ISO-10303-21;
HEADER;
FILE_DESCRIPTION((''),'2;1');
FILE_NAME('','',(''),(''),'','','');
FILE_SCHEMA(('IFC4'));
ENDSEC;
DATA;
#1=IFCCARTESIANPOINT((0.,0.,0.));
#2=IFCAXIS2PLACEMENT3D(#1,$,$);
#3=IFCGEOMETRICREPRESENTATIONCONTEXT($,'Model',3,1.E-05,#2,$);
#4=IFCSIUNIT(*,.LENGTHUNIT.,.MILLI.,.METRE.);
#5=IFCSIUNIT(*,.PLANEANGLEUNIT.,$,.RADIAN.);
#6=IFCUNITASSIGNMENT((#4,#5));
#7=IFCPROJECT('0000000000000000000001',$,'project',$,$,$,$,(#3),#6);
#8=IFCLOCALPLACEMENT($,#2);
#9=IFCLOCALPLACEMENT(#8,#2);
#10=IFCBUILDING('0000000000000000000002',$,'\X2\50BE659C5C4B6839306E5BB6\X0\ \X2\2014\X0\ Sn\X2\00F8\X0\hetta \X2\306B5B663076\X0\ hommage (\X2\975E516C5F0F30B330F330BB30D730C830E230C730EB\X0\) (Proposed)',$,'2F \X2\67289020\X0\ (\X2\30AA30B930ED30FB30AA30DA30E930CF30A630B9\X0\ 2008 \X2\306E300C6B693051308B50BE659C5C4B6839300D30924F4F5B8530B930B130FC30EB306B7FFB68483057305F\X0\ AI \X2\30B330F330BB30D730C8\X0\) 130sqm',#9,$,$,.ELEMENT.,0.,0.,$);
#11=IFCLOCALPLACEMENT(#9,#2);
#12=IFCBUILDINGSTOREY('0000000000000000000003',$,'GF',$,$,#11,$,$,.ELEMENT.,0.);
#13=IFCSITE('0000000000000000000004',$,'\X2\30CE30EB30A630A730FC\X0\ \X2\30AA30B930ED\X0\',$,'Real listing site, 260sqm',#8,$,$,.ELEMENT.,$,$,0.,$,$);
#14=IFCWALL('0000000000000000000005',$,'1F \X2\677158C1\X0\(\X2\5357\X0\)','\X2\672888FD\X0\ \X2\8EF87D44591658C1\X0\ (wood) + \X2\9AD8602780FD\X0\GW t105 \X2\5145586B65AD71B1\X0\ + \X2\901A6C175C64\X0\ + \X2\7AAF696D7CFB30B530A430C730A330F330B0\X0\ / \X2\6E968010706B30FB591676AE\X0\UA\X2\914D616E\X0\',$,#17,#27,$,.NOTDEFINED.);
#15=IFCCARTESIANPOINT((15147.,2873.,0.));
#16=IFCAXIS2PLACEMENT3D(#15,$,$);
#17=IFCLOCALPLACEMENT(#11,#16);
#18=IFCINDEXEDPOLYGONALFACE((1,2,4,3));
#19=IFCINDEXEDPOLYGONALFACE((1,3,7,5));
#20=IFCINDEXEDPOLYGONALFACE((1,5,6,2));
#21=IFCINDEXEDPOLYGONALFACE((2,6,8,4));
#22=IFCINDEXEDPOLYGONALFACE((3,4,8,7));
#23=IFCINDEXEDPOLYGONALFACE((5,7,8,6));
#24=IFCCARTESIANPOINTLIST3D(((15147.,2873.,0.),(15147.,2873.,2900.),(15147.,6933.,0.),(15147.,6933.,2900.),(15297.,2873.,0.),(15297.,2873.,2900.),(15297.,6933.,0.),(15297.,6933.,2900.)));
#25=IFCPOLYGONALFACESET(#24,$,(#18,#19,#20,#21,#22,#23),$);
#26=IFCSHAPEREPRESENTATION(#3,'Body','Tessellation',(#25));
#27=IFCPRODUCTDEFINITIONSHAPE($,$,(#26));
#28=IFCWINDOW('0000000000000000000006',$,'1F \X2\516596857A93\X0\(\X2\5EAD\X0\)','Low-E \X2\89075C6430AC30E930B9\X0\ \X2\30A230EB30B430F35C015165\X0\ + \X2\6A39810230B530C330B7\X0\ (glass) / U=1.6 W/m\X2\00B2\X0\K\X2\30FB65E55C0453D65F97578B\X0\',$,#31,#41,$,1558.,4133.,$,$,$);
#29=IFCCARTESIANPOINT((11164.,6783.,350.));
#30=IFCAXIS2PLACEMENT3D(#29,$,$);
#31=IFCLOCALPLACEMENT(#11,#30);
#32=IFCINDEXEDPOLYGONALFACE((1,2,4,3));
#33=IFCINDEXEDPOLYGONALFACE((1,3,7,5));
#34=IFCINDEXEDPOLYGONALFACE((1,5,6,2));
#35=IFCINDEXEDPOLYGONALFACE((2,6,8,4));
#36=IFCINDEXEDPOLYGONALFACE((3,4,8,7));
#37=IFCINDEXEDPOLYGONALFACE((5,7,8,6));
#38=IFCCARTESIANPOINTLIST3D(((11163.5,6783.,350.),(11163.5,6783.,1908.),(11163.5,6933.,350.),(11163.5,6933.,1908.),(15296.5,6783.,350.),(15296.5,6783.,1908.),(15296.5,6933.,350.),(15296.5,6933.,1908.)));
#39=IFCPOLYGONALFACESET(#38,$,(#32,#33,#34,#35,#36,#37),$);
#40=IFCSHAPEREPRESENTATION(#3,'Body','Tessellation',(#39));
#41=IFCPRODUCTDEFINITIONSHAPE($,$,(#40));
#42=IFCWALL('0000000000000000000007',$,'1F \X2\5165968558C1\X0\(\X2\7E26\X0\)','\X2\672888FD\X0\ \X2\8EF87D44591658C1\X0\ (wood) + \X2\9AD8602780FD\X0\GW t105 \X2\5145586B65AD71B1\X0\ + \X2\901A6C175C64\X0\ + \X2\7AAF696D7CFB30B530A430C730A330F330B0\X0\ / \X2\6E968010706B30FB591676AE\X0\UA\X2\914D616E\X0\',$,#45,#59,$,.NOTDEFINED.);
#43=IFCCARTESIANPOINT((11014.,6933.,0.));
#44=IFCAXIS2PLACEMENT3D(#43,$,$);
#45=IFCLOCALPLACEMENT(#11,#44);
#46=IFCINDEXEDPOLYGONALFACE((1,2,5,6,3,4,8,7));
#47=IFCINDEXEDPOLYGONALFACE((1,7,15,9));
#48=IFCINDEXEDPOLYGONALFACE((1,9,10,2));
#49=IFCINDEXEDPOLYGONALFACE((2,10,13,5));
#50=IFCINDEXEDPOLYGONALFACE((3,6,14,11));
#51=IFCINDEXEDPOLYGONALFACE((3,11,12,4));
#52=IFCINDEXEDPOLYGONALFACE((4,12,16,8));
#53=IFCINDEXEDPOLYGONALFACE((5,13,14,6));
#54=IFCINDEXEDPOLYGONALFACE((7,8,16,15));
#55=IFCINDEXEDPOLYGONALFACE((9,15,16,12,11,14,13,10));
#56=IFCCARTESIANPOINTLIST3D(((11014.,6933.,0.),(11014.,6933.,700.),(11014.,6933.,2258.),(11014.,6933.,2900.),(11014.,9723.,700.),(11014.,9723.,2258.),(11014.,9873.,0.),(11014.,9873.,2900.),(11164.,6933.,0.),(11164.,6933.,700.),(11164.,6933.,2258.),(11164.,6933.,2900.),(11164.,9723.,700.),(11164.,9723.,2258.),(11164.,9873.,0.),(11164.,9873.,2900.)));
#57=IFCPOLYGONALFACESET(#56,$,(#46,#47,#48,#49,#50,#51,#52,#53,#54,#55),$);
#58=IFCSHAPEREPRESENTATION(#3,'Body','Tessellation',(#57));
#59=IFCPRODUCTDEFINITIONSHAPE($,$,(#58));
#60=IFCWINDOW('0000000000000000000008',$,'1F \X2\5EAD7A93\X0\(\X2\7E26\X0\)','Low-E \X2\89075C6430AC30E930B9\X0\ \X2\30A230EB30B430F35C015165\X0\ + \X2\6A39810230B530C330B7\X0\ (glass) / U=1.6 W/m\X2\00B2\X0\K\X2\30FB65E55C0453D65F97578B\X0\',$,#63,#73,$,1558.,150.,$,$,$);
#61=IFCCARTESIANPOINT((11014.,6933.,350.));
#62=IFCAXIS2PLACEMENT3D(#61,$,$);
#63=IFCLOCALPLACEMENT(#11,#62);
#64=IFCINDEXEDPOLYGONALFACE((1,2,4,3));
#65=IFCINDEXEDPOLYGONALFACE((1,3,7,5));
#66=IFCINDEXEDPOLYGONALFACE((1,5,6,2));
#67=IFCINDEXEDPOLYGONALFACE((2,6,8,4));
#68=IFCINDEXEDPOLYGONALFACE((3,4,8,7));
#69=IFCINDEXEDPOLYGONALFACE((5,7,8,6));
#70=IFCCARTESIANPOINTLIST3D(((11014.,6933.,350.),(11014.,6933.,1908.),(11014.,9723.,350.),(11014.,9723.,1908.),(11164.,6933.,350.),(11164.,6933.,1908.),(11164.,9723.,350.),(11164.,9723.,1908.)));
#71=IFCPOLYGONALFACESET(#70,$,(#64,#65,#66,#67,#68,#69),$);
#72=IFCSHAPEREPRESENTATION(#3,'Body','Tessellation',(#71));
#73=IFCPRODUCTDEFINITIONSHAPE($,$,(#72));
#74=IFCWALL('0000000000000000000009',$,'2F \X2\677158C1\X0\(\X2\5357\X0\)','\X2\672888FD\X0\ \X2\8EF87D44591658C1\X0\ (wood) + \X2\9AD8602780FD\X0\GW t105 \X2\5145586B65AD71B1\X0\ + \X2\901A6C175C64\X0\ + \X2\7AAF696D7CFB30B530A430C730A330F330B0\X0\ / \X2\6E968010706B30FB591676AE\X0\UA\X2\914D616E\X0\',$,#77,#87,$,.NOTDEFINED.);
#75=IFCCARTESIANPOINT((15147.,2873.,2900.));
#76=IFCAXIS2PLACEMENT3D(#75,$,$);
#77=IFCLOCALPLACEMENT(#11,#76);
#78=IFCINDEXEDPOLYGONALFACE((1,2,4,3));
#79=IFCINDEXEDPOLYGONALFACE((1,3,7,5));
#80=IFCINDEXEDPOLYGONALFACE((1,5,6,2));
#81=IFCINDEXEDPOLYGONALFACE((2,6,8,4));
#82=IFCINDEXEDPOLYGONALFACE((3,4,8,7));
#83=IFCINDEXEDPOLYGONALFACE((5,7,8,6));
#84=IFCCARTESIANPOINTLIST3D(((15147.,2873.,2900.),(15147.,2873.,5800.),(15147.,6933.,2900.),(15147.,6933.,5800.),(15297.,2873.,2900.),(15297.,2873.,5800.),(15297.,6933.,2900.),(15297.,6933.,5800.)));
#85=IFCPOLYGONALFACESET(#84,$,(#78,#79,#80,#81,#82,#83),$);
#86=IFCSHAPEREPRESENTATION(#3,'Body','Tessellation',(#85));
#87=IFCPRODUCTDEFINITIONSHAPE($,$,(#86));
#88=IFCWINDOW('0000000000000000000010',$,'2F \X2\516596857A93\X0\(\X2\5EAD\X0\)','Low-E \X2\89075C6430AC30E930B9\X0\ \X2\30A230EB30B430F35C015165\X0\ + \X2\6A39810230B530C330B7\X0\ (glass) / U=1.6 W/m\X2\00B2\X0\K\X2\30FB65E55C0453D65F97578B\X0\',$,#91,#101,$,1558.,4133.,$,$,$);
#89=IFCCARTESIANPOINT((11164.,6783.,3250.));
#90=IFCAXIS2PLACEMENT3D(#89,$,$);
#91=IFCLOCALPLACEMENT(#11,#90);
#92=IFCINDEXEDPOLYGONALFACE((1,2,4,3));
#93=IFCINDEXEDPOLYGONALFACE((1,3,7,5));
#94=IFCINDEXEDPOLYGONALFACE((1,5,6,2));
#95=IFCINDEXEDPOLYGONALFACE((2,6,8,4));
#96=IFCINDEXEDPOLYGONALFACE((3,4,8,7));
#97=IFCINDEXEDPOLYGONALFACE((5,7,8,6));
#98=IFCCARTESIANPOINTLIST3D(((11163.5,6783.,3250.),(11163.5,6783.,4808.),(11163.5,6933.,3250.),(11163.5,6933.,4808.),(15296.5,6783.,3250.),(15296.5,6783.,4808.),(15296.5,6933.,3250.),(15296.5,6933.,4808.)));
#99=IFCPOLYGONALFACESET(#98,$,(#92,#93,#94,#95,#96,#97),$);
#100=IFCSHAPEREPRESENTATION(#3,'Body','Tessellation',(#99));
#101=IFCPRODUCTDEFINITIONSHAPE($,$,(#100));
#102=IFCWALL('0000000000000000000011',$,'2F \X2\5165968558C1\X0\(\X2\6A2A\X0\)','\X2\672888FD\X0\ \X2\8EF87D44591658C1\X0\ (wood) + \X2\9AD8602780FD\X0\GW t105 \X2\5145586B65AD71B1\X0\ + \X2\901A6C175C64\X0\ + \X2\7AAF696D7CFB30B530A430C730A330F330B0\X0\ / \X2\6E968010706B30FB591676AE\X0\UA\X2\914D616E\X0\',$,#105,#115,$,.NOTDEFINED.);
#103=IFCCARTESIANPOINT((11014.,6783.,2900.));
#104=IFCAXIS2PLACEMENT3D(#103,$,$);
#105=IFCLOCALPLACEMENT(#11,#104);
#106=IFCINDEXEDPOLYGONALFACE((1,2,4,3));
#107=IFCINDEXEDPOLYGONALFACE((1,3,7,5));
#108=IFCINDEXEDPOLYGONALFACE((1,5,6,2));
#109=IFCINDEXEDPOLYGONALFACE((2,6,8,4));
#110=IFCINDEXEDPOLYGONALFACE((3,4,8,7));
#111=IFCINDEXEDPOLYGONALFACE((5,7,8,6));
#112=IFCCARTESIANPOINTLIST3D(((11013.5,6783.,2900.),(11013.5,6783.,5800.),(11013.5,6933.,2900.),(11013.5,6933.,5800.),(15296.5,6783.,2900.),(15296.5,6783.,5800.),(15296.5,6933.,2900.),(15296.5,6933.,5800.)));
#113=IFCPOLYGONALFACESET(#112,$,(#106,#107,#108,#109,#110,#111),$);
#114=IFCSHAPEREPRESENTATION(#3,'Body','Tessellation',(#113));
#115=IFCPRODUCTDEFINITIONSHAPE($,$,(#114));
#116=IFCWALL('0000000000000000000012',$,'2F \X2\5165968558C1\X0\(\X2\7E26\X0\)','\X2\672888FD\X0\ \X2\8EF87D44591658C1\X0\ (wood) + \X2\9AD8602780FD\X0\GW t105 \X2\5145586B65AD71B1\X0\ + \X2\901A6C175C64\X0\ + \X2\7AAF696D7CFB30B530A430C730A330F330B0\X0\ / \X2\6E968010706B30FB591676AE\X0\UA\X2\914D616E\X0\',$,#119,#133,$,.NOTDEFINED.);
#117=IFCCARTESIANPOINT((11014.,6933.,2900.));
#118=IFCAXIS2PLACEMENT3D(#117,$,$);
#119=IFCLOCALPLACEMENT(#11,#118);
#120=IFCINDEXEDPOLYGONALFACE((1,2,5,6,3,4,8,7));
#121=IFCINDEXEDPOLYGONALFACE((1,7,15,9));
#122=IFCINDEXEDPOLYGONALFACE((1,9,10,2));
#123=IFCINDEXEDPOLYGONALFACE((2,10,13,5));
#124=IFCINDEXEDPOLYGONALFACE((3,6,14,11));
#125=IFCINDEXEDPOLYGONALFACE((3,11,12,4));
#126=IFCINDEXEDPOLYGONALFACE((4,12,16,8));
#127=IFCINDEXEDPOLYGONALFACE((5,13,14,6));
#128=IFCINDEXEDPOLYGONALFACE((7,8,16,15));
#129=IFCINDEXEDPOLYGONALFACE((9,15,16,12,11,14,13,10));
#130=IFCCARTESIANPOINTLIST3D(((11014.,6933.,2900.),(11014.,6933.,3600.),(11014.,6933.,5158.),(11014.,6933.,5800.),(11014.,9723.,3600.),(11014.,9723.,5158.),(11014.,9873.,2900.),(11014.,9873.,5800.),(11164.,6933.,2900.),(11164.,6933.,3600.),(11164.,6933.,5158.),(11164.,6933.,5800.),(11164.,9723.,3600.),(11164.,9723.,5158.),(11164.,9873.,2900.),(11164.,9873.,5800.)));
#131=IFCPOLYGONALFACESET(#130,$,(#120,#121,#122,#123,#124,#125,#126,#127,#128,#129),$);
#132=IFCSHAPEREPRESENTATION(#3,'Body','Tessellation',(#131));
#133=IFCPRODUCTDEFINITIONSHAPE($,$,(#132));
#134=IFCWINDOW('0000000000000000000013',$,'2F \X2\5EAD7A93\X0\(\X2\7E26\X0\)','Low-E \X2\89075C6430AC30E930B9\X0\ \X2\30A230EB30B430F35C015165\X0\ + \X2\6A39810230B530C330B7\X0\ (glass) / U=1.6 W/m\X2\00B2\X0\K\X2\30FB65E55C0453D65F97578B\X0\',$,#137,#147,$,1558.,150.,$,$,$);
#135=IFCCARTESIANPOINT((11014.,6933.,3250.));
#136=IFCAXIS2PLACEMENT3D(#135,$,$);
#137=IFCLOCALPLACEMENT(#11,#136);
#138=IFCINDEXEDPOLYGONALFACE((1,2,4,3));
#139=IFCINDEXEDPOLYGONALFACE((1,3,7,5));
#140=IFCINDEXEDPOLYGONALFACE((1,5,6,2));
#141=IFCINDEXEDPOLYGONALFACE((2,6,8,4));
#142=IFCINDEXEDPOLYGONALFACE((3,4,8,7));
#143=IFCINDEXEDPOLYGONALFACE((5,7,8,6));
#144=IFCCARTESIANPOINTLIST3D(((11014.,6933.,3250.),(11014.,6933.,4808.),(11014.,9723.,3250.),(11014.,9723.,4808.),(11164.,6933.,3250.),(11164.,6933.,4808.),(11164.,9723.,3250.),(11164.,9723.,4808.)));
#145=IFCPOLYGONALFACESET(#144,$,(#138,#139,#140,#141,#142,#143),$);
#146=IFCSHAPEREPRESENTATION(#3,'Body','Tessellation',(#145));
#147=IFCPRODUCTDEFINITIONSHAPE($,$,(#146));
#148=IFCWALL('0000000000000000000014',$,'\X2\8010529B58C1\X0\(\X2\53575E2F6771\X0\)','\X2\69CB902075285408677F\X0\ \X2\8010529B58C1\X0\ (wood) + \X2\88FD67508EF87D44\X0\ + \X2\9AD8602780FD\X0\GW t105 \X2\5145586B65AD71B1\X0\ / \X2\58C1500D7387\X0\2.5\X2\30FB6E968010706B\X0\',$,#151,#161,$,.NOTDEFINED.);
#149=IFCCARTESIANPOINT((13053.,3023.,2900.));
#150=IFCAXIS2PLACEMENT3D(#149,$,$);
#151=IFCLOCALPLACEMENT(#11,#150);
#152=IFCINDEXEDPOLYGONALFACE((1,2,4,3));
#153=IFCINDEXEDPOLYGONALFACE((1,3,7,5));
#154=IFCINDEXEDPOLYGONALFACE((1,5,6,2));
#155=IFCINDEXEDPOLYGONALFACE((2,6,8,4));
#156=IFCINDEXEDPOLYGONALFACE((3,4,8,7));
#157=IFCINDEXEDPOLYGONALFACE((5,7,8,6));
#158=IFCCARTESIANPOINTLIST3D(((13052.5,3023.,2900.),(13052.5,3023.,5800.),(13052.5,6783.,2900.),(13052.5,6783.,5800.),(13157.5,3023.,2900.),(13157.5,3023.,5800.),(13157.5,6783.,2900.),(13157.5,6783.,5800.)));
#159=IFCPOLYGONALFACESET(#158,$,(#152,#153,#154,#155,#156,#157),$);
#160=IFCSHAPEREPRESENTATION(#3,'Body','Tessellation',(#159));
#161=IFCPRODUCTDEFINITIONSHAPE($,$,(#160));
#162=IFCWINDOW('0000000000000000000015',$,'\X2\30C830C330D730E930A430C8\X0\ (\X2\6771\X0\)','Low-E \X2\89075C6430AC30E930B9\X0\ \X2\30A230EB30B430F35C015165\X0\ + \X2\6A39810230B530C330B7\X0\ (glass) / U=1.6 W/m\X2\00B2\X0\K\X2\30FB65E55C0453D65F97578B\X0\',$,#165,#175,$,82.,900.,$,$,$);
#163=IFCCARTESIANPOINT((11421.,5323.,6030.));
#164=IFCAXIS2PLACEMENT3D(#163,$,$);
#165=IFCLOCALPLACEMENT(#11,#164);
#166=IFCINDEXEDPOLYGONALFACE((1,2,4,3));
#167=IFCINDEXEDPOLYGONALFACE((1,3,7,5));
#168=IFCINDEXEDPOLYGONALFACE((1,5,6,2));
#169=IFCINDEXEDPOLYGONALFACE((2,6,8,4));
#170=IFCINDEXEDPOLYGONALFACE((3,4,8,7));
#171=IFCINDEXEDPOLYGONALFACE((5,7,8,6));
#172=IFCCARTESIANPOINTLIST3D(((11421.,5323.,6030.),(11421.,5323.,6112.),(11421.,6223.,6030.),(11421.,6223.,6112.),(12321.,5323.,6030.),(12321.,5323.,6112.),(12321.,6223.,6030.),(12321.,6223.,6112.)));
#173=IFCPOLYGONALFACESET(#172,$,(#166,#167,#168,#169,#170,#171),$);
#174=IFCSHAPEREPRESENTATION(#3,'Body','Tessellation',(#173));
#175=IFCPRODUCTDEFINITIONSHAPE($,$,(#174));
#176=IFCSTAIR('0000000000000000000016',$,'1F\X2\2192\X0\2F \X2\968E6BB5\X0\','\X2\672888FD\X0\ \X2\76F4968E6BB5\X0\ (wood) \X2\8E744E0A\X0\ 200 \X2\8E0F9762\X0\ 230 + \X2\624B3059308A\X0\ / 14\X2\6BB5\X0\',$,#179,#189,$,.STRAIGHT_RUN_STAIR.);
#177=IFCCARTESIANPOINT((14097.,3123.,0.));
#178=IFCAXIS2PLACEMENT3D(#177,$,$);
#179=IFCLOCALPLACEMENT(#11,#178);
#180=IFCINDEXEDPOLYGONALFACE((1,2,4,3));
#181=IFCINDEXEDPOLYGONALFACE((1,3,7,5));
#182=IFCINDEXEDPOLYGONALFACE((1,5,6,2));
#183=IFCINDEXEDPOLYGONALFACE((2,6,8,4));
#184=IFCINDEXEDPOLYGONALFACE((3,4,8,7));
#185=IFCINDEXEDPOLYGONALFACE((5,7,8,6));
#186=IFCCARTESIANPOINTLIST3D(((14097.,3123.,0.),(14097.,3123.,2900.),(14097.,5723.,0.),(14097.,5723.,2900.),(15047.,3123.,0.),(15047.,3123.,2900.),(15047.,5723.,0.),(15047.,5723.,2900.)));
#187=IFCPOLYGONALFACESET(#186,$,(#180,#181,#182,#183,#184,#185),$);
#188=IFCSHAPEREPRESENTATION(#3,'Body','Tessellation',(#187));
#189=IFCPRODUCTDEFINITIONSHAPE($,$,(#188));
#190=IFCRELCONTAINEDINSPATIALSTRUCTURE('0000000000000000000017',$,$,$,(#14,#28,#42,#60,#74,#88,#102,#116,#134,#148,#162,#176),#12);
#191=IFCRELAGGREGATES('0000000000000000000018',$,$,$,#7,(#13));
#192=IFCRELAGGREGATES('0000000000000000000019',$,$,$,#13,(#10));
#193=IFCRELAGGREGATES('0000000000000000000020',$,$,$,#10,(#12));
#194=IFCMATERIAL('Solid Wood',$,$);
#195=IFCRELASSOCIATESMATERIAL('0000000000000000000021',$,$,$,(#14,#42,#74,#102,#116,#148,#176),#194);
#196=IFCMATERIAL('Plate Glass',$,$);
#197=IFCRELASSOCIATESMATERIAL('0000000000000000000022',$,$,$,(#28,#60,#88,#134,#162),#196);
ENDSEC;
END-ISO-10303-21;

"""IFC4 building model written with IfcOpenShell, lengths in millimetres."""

from ifc_helpers import new_model, si_unit, frame, frame_2d, origin, place, context, project, spatial, rectangle, extrude, material, element, fill, save


model = new_model("IFC4")

# Units and contexts
model_context = context("Model", 3, precision=1e-05, world=origin())
ifc_project = project(units=[si_unit("LENGTHUNIT", "METRE", prefix="MILLI"), si_unit("PLANEANGLEUNIT", "RADIAN")], contexts=[model_context])

# Site, building, storey
site_placement = place(None, origin())
site = spatial("IfcSite", under=ifc_project, at=site_placement, Name="ノルウェー オスロ", ObjectType="Real listing site, 260sqm", CompositionType="ELEMENT", RefElevation=0.0)
building_placement = place(site_placement, origin())
building = spatial("IfcBuilding", under=site, at=building_placement, Name="傾斜屋根の家 — Snøhetta に学ぶ hommage (非公式コンセプトモデル) (Proposed)", ObjectType="2F 木造 (オスロ・オペラハウス 2008 の「歩ける傾斜屋根」を住宅スケールに翻案した AI コンセプト) 130sqm", CompositionType="ELEMENT", ElevationOfRefHeight=0.0, ElevationOfTerrain=0.0)
storey_placement = place(building_placement, origin())
storey = spatial("IfcBuildingStorey", under=building, at=storey_placement, Name="GF", CompositionType="ELEMENT", Elevation=0.0)

# Shared definitions
ifc_material_1 = material(Name="Solid Wood")

# Wall, opening, window
wall_1_placement = place(storey_placement, frame((15147.0, 2873.0, 0.0)))
wall_1 = element("IfcWall", 1, at=wall_1_placement, inside=storey, material=ifc_material_1, Name="1F 東壁(南)", Description="木製 軸組外壁 (wood) + 高性能GW t105 充填断熱 + 通気層 + 窯業系サイディング / 準耐火・外皮UA配慮", PredefinedType="NOTDEFINED", context=model_context, shape_type="SweptSolid", body=[
    extrude(rectangle(XDim=150.0, YDim=4060.0, at=frame_2d((75.0, 2030.0))), frame((15147.0, 2873.0, 0.0)), (0.0, 0.0, 1.0), 2900.0),
])
opening_1_placement = place(storey_placement, frame((11164.0, 6783.0, 350.0)))
opening_1 = element("IfcOpeningElement", 2, at=opening_1_placement, cuts=wall_1, PredefinedType="NOTDEFINED", context=model_context, shape_type="SweptSolid", body=[
    extrude(rectangle(XDim=4133.0, YDim=150.0, at=frame_2d((2066.0, 75.0))), frame((11164.0, 6783.0, 350.0)), (0.0, 0.0, 1.0), 1558.0),
])
ifc_material_2 = material(Name="Plate Glass")
window_1_placement = place(storey_placement, frame((11164.0, 6783.0, 350.0)))
window_1 = element("IfcWindow", 3, at=window_1_placement, inside=storey, material=ifc_material_2, Name="1F 入隅窓(庭)", Description="Low-E 複層ガラス アルゴン封入 + 樹脂サッシ (glass) / U=1.6 W/m²K・日射取得型", OverallHeight=1558.0, OverallWidth=4133.0, context=model_context, shape_type="SweptSolid", body=[
    extrude(rectangle(XDim=4133.0, YDim=150.0, at=frame_2d((2066.0, 75.0))), frame((11164.0, 6783.0, 350.0)), (0.0, 0.0, 1.0), 1558.0),
])
fill(opening_1, window_1)

# Wall, opening, window
wall_2_placement = place(storey_placement, frame((11014.0, 6933.0, 0.0)))
wall_2 = element("IfcWall", 4, at=wall_2_placement, inside=storey, material=ifc_material_1, Name="1F 入隅壁(縦)", Description="木製 軸組外壁 (wood) + 高性能GW t105 充填断熱 + 通気層 + 窯業系サイディング / 準耐火・外皮UA配慮", PredefinedType="NOTDEFINED", context=model_context, shape_type="SweptSolid", body=[
    extrude(rectangle(XDim=150.0, YDim=2940.0, at=frame_2d((75.0, 1470.0))), frame((11014.0, 6933.0, 0.0)), (0.0, 0.0, 1.0), 2900.0),
])
opening_2_placement = place(storey_placement, frame((11014.0, 6933.0, 350.0)))
opening_2 = element("IfcOpeningElement", 5, at=opening_2_placement, cuts=wall_2, PredefinedType="NOTDEFINED", context=model_context, shape_type="SweptSolid", body=[
    extrude(rectangle(XDim=150.0, YDim=2790.0, at=frame_2d((75.0, 1395.0))), frame((11014.0, 6933.0, 350.0)), (0.0, 0.0, 1.0), 1558.0),
])
window_2_placement = place(storey_placement, frame((11014.0, 6933.0, 350.0)))
window_2 = element("IfcWindow", 6, at=window_2_placement, inside=storey, material=ifc_material_2, Name="1F 庭窓(縦)", Description="Low-E 複層ガラス アルゴン封入 + 樹脂サッシ (glass) / U=1.6 W/m²K・日射取得型", OverallHeight=1558.0, OverallWidth=150.0, context=model_context, shape_type="SweptSolid", body=[
    extrude(rectangle(XDim=150.0, YDim=2790.0, at=frame_2d((75.0, 1395.0))), frame((11014.0, 6933.0, 350.0)), (0.0, 0.0, 1.0), 1558.0),
])
fill(opening_2, window_2)

# Wall, opening, window
wall_3_placement = place(storey_placement, frame((15147.0, 2873.0, 2900.0)))
wall_3 = element("IfcWall", 7, at=wall_3_placement, inside=storey, material=ifc_material_1, Name="2F 東壁(南)", Description="木製 軸組外壁 (wood) + 高性能GW t105 充填断熱 + 通気層 + 窯業系サイディング / 準耐火・外皮UA配慮", PredefinedType="NOTDEFINED", context=model_context, shape_type="SweptSolid", body=[
    extrude(rectangle(XDim=150.0, YDim=4060.0, at=frame_2d((75.0, 2030.0))), frame((15147.0, 2873.0, 2900.0)), (0.0, 0.0, 1.0), 2900.0),
])
opening_3_placement = place(storey_placement, frame((11164.0, 6783.0, 3250.0)))
opening_3 = element("IfcOpeningElement", 8, at=opening_3_placement, cuts=wall_3, PredefinedType="NOTDEFINED", context=model_context, shape_type="SweptSolid", body=[
    extrude(rectangle(XDim=4133.0, YDim=150.0, at=frame_2d((2066.0, 75.0))), frame((11164.0, 6783.0, 3250.0)), (0.0, 0.0, 1.0), 1558.0),
])
window_3_placement = place(storey_placement, frame((11164.0, 6783.0, 3250.0)))
window_3 = element("IfcWindow", 9, at=window_3_placement, inside=storey, material=ifc_material_2, Name="2F 入隅窓(庭)", Description="Low-E 複層ガラス アルゴン封入 + 樹脂サッシ (glass) / U=1.6 W/m²K・日射取得型", OverallHeight=1558.0, OverallWidth=4133.0, context=model_context, shape_type="SweptSolid", body=[
    extrude(rectangle(XDim=4133.0, YDim=150.0, at=frame_2d((2066.0, 75.0))), frame((11164.0, 6783.0, 3250.0)), (0.0, 0.0, 1.0), 1558.0),
])
fill(opening_3, window_3)

# Wall
wall_4_placement = place(storey_placement, frame((11014.0, 6783.0, 2900.0)))
element("IfcWall", 10, at=wall_4_placement, inside=storey, material=ifc_material_1, Name="2F 入隅壁(横)", Description="木製 軸組外壁 (wood) + 高性能GW t105 充填断熱 + 通気層 + 窯業系サイディング / 準耐火・外皮UA配慮", PredefinedType="NOTDEFINED", context=model_context, shape_type="SweptSolid", body=[
    extrude(rectangle(XDim=4283.0, YDim=150.0, at=frame_2d((2141.0, 75.0))), frame((11014.0, 6783.0, 2900.0)), (0.0, 0.0, 1.0), 2900.0),
])

# Wall, opening, window
wall_5_placement = place(storey_placement, frame((11014.0, 6933.0, 2900.0)))
wall_5 = element("IfcWall", 11, at=wall_5_placement, inside=storey, material=ifc_material_1, Name="2F 入隅壁(縦)", Description="木製 軸組外壁 (wood) + 高性能GW t105 充填断熱 + 通気層 + 窯業系サイディング / 準耐火・外皮UA配慮", PredefinedType="NOTDEFINED", context=model_context, shape_type="SweptSolid", body=[
    extrude(rectangle(XDim=150.0, YDim=2940.0, at=frame_2d((75.0, 1470.0))), frame((11014.0, 6933.0, 2900.0)), (0.0, 0.0, 1.0), 2900.0),
])
opening_4_placement = place(storey_placement, frame((11014.0, 6933.0, 3250.0)))
opening_4 = element("IfcOpeningElement", 12, at=opening_4_placement, cuts=wall_5, PredefinedType="NOTDEFINED", context=model_context, shape_type="SweptSolid", body=[
    extrude(rectangle(XDim=150.0, YDim=2790.0, at=frame_2d((75.0, 1395.0))), frame((11014.0, 6933.0, 3250.0)), (0.0, 0.0, 1.0), 1558.0),
])
window_4_placement = place(storey_placement, frame((11014.0, 6933.0, 3250.0)))
window_4 = element("IfcWindow", 13, at=window_4_placement, inside=storey, material=ifc_material_2, Name="2F 庭窓(縦)", Description="Low-E 複層ガラス アルゴン封入 + 樹脂サッシ (glass) / U=1.6 W/m²K・日射取得型", OverallHeight=1558.0, OverallWidth=150.0, context=model_context, shape_type="SweptSolid", body=[
    extrude(rectangle(XDim=150.0, YDim=2790.0, at=frame_2d((75.0, 1395.0))), frame((11014.0, 6933.0, 3250.0)), (0.0, 0.0, 1.0), 1558.0),
])
fill(opening_4, window_4)

# Wall
wall_6_placement = place(storey_placement, frame((13053.0, 3023.0, 2900.0)))
element("IfcWall", 14, at=wall_6_placement, inside=storey, material=ifc_material_1, Name="耐力壁(南帯東)", Description="構造用合板 耐力壁 (wood) + 製材軸組 + 高性能GW t105 充填断熱 / 壁倍率2.5・準耐火", PredefinedType="NOTDEFINED", context=model_context, shape_type="SweptSolid", body=[
    extrude(rectangle(XDim=105.0, YDim=3760.0, at=frame_2d((52.0, 1880.0))), frame((13053.0, 3023.0, 2900.0)), (0.0, 0.0, 1.0), 2900.0),
])

# Window
window_5_placement = place(storey_placement, frame((11421.0, 5323.0, 6030.0)))
element("IfcWindow", 15, at=window_5_placement, inside=storey, material=ifc_material_2, Name="トップライト (東)", Description="Low-E 複層ガラス アルゴン封入 + 樹脂サッシ (glass) / U=1.6 W/m²K・日射取得型", OverallHeight=82.0, OverallWidth=900.0, context=model_context, shape_type="SweptSolid", body=[
    extrude(rectangle(XDim=900.0, YDim=900.0, at=frame_2d((450.0, 450.0))), frame((11421.0, 5323.0, 6030.0)), (0.0, 0.0, 1.0), 82.0),
])

# Stair
stair_placement = place(storey_placement, frame((14097.0, 3123.0, 0.0)))
element("IfcStair", 16, at=stair_placement, inside=storey, material=ifc_material_1, Name="1F→2F 階段", Description="木製 直階段 (wood) 蹴上 200 踏面 230 + 手すり / 14段", PredefinedType="STRAIGHT_RUN_STAIR", context=model_context, shape_type="SweptSolid", body=[
    extrude(rectangle(XDim=950.0, YDim=2600.0, at=frame_2d((475.0, 1300.0))), frame((14097.0, 3123.0, 0.0)), (0.0, 0.0, 1.0), 2900.0),
])

save(model, "model.ifc")
